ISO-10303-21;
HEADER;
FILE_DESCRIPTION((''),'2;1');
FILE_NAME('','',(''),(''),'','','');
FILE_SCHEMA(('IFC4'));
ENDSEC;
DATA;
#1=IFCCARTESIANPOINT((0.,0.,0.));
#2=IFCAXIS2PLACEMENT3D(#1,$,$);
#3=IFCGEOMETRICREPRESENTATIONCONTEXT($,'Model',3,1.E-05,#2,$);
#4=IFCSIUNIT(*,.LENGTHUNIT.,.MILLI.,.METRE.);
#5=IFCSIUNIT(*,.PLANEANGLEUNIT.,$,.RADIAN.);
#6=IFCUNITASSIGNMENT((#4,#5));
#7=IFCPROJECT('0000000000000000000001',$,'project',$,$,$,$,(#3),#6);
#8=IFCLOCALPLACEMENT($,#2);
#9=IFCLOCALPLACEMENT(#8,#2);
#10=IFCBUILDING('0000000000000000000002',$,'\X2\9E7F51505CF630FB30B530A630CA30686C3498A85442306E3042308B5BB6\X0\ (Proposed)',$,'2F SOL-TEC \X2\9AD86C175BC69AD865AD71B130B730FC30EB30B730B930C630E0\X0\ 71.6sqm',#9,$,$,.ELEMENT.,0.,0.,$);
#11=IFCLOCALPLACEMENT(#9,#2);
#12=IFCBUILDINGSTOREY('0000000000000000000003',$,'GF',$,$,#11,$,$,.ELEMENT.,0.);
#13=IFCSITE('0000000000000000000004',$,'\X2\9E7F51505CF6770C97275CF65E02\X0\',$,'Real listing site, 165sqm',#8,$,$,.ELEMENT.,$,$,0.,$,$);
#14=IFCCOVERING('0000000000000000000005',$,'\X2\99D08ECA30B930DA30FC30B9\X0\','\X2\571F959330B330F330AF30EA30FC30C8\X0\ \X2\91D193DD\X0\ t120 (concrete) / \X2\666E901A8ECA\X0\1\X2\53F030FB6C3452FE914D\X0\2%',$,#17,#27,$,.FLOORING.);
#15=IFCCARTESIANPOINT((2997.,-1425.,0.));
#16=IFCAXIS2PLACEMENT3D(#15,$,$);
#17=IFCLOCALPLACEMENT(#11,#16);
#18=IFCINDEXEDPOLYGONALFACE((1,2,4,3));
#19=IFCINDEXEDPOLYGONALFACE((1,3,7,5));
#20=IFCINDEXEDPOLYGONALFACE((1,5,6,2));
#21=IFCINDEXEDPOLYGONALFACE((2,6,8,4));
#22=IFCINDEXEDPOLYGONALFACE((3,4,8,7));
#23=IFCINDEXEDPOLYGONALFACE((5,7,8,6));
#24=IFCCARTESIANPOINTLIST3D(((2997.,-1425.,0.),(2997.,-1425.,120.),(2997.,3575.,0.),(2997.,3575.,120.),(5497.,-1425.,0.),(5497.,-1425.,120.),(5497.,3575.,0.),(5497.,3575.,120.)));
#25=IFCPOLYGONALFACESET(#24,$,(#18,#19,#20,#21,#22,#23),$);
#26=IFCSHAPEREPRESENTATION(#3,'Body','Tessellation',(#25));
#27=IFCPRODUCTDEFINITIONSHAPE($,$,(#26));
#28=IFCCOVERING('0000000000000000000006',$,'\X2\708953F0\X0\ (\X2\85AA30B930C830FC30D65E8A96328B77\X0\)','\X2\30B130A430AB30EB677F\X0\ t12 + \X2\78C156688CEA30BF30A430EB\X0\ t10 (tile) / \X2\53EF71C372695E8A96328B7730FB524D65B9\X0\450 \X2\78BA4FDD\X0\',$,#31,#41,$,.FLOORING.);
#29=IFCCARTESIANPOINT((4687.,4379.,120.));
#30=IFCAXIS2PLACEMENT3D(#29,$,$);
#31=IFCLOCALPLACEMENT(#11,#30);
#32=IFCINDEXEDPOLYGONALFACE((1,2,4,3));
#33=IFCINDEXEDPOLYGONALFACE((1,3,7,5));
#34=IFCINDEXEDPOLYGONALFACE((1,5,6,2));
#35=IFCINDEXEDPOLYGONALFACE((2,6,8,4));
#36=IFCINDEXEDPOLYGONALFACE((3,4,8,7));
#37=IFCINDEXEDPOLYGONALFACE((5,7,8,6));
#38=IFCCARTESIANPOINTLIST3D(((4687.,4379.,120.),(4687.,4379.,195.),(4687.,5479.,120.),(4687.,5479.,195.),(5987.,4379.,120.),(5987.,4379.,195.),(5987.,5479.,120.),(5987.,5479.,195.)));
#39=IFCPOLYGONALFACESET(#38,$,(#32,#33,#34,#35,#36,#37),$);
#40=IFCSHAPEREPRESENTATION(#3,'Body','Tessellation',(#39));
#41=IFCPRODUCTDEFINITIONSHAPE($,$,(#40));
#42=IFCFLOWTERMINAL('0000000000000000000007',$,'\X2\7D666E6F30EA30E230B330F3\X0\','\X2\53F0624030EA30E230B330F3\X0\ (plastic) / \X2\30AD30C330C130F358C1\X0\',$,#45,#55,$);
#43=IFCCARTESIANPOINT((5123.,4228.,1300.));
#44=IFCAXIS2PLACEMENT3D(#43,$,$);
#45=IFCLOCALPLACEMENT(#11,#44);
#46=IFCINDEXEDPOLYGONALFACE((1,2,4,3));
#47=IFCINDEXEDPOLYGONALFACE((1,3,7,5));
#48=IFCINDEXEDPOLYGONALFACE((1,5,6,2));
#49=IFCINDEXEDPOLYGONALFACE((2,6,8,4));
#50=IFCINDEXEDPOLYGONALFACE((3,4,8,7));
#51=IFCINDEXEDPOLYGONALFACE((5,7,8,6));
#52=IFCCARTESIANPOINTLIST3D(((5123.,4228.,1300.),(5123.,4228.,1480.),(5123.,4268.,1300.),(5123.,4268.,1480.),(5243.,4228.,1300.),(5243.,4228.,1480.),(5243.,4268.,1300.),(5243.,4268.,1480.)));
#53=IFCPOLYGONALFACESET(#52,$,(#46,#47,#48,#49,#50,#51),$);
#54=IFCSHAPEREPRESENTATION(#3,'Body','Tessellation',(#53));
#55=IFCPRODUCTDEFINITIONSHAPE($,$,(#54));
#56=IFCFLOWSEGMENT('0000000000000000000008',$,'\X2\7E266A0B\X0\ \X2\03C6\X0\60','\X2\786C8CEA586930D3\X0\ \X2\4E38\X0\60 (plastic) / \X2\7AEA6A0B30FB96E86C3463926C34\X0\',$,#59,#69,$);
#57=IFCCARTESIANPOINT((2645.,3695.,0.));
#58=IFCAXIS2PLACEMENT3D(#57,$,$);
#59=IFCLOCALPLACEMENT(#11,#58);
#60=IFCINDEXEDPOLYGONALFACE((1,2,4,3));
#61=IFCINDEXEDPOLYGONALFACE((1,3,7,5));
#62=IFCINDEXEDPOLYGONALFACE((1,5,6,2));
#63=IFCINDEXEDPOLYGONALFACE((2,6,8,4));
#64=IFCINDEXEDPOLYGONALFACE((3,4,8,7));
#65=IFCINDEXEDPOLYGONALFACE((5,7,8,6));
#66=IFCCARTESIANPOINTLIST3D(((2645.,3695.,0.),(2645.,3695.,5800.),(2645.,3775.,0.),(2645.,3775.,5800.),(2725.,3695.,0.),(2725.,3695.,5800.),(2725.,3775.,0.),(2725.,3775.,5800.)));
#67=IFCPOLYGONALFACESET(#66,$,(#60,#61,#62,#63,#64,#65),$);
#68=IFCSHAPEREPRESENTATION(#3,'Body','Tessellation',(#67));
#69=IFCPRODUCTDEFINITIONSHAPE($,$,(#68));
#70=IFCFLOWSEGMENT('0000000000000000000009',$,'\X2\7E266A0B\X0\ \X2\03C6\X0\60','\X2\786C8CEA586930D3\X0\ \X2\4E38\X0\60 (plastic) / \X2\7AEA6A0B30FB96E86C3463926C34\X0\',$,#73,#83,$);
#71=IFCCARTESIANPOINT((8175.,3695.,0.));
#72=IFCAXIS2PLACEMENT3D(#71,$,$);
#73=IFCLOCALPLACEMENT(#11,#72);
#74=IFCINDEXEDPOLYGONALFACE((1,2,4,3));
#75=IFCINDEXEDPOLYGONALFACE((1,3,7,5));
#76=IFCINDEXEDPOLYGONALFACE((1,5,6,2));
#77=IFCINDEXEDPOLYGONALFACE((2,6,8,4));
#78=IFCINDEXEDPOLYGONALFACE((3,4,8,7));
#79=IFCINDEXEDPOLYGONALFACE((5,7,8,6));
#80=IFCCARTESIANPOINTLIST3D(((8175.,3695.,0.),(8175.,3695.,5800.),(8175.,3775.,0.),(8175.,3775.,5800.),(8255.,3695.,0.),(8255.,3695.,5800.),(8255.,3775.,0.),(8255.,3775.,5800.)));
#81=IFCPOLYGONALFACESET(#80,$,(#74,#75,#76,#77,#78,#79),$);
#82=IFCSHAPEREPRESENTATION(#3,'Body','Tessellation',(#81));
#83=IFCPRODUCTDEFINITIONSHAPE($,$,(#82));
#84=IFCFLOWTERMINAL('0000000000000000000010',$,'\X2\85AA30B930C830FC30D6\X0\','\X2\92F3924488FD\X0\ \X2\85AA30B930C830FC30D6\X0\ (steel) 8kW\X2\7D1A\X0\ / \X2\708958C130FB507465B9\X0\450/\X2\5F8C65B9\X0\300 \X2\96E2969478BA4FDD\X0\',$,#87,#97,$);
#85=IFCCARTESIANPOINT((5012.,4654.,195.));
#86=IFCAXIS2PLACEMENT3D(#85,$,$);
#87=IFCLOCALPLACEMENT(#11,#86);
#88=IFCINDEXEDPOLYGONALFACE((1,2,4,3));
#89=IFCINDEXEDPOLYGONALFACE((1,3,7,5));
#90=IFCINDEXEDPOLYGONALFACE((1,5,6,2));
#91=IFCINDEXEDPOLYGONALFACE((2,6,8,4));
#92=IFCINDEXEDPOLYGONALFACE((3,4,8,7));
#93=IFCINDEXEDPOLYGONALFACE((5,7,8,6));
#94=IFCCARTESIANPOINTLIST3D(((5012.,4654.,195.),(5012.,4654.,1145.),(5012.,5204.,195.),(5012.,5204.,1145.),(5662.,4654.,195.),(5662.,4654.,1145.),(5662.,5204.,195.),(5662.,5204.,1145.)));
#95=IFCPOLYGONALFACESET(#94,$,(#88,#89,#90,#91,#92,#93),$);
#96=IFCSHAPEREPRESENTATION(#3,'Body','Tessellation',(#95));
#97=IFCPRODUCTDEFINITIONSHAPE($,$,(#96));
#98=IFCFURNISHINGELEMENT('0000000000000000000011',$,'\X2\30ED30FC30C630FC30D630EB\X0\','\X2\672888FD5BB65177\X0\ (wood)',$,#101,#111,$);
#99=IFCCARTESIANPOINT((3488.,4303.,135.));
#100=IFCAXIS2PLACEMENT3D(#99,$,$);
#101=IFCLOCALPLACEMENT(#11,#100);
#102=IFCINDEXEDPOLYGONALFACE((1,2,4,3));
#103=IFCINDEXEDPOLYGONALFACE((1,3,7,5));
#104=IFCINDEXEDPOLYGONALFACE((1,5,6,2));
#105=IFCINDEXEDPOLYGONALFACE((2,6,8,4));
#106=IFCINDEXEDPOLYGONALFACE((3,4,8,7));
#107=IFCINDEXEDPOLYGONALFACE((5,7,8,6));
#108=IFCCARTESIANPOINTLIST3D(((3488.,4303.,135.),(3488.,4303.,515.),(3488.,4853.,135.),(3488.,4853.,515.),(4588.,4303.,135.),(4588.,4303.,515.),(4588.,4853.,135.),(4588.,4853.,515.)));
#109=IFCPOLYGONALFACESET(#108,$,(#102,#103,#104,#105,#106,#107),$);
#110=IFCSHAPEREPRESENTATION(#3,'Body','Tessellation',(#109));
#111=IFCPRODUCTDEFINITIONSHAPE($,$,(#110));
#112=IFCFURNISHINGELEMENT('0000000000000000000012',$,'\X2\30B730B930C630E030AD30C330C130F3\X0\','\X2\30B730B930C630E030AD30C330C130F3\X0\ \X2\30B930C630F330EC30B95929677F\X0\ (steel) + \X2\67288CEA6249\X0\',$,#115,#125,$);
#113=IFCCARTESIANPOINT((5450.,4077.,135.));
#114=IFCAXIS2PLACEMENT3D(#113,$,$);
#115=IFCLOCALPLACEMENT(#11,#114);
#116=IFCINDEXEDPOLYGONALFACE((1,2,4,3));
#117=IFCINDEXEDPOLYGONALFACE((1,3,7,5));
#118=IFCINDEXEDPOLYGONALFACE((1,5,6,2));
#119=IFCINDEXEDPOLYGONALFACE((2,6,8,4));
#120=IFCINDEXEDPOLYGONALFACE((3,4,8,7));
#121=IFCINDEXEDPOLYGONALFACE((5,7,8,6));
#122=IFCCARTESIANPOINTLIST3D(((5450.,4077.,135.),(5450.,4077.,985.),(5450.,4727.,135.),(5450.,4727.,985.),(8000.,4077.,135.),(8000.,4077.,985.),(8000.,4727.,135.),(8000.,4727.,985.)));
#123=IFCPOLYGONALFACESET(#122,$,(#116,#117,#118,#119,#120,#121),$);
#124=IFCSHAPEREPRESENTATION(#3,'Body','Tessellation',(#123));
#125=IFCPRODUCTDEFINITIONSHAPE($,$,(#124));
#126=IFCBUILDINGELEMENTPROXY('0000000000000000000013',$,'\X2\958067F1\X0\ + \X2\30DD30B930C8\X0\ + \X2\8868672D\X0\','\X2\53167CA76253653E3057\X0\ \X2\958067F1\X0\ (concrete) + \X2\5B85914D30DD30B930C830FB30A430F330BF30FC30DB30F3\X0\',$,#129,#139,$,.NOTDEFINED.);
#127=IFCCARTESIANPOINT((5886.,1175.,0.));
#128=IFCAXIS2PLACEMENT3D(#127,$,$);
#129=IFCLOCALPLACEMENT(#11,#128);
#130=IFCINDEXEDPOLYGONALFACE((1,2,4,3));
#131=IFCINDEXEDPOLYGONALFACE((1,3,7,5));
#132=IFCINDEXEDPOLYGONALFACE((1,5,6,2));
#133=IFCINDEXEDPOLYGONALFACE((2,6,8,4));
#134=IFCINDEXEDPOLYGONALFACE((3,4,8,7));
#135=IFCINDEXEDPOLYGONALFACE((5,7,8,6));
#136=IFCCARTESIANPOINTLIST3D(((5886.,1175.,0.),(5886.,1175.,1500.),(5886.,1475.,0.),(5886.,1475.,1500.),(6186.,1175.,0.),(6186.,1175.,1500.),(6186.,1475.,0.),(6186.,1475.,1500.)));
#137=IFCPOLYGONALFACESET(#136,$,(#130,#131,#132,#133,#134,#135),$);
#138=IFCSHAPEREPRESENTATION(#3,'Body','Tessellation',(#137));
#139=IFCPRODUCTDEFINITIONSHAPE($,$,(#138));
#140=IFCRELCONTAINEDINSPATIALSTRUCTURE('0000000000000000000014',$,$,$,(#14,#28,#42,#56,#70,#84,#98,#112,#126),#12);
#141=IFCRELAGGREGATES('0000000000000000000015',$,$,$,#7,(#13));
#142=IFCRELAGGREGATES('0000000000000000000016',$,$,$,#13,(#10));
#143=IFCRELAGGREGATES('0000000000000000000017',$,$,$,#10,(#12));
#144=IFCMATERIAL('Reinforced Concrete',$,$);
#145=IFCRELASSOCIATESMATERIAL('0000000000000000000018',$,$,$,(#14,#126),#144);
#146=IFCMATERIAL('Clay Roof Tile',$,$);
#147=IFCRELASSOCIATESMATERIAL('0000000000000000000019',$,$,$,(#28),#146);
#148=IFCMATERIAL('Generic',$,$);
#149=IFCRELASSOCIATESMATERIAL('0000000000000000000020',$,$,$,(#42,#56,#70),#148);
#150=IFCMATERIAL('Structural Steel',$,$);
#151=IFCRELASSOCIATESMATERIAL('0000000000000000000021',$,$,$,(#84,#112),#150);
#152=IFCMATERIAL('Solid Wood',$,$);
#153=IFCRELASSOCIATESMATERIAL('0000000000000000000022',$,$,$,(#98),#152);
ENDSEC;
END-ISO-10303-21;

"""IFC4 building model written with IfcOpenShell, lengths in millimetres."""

from ifc_helpers import new_model, si_unit, frame, frame_2d, origin, place, context, project, spatial, rectangle, extrude, material, element, save


model = new_model("IFC4")

# Units and contexts
model_context = context("Model", 3, precision=1e-05, world=origin())
ifc_project = project(units=[si_unit("LENGTHUNIT", "METRE", prefix="MILLI"), si_unit("PLANEANGLEUNIT", "RADIAN")], contexts=[model_context])

# Site, building, storey
site_placement = place(None, origin())
site = spatial("IfcSite", under=ifc_project, at=site_placement, Name="鹿児島県霧島市", ObjectType="Real listing site, 165sqm", CompositionType="ELEMENT", RefElevation=0.0)
building_placement = place(site_placement, origin())
building = spatial("IfcBuilding", under=site, at=building_placement, Name="鹿児島・サウナと水風呂のある家 (Proposed)", ObjectType="2F SOL-TEC 高気密高断熱シールシステム 71.6sqm", CompositionType="ELEMENT", ElevationOfRefHeight=0.0, ElevationOfTerrain=0.0)
storey_placement = place(building_placement, origin())
storey = spatial("IfcBuildingStorey", under=building, at=storey_placement, Name="GF", CompositionType="ELEMENT", Elevation=0.0)

# Shared definitions
ifc_material_1 = material(Name="Solid Wood")

# Shared definitions
ifc_material_2 = material(Name="Reinforced Concrete")

# Coverings
ifc_material_3 = material(Name="Generic")
covering_1_placement = place(storey_placement, frame((2997.0, -1425.0, 0.0)))
element("IfcCovering", 1, at=covering_1_placement, inside=storey, material=ifc_material_2, Name="駐車スペース", Description="土間コンクリート 金鏝 t120 (concrete) / 普通車1台・水勾配2%", PredefinedType="FLOORING", context=model_context, shape_type="SweptSolid", body=[
    extrude(rectangle(XDim=2500.0, YDim=5000.0, at=frame_2d((1250.0, 2500.0))), frame((2997.0, -1425.0, 0.0)), (0.0, 0.0, 1.0), 120.0),
])
ifc_material_4 = material(Name="Clay Roof Tile")
covering_2_placement = place(storey_placement, frame((4687.0, 4379.0, 120.0)))
element("IfcCovering", 2, at=covering_2_placement, inside=storey, material=ifc_material_4, Name="炉台 (薪ストーブ床防護)", Description="ケイカル板 t12 + 磁器質タイル t10 (tile) / 可燃物床防護・前方450 確保", PredefinedType="FLOORING", context=model_context, shape_type="SweptSolid", body=[
    extrude(rectangle(XDim=1300.0, YDim=1100.0, at=frame_2d((650.0, 550.0))), frame((4687.0, 4379.0, 120.0)), (0.0, 0.0, 1.0), 75.0),
])

# Flow terminal
flow_terminal_1_placement = place(storey_placement, frame((5123.0, 4228.0, 1300.0)))
element("IfcFlowTerminal", 3, at=flow_terminal_1_placement, inside=storey, material=ifc_material_3, Name="給湯リモコン", Description="台所リモコン (plastic) / キッチン壁", context=model_context, shape_type="SweptSolid", body=[
    extrude(rectangle(XDim=120.0, YDim=40.0, at=frame_2d((60.0, 20.0))), frame((5123.0, 4228.0, 1300.0)), (0.0, 0.0, 1.0), 180.0),
])

# Flow segments
flow_segment_1_placement = place(storey_placement, frame((2645.0, 3695.0, 0.0)))
element("IfcFlowSegment", 4, at=flow_segment_1_placement, inside=storey, material=ifc_material_3, Name="縦樋 φ60", Description="硬質塩ビ 丸60 (plastic) / 竪樋・雨水排水", context=model_context, shape_type="SweptSolid", body=[
    extrude(rectangle(XDim=80.0, YDim=80.0, at=frame_2d((40.0, 40.0))), frame((2645.0, 3695.0, 0.0)), (0.0, 0.0, 1.0), 5800.0),
])
flow_segment_2_placement = place(storey_placement, frame((8175.0, 3695.0, 0.0)))
element("IfcFlowSegment", 5, at=flow_segment_2_placement, inside=storey, material=ifc_material_3, Name="縦樋 φ60", Description="硬質塩ビ 丸60 (plastic) / 竪樋・雨水排水", context=model_context, shape_type="SweptSolid", body=[
    extrude(rectangle(XDim=80.0, YDim=80.0, at=frame_2d((40.0, 40.0))), frame((8175.0, 3695.0, 0.0)), (0.0, 0.0, 1.0), 5800.0),
])

# Flow terminal
ifc_material_5 = material(Name="Structural Steel")
flow_terminal_2_placement = place(storey_placement, frame((5012.0, 4654.0, 195.0)))
element("IfcFlowTerminal", 6, at=flow_terminal_2_placement, inside=storey, material=ifc_material_5, Name="薪ストーブ", Description="鋳鉄製 薪ストーブ (steel) 8kW級 / 炉壁・側方450/後方300 離隔確保", context=model_context, shape_type="SweptSolid", body=[
    extrude(rectangle(XDim=650.0, YDim=550.0, at=frame_2d((325.0, 275.0))), frame((5012.0, 4654.0, 195.0)), (0.0, 0.0, 1.0), 950.0),
])

# Furnishing elements
furnishing_1_placement = place(storey_placement, frame((3488.0, 4303.0, 135.0)))
element("IfcFurnishingElement", 7, at=furnishing_1_placement, inside=storey, material=ifc_material_1, Name="ローテーブル", Description="木製家具 (wood)", context=model_context, shape_type="SweptSolid", body=[
    extrude(rectangle(XDim=1100.0, YDim=550.0, at=frame_2d((550.0, 275.0))), frame((3488.0, 4303.0, 135.0)), (0.0, 0.0, 1.0), 380.0),
])
furnishing_2_placement = place(storey_placement, frame((5450.0, 4077.0, 135.0)))
element("IfcFurnishingElement", 8, at=furnishing_2_placement, inside=storey, material=ifc_material_5, Name="システムキッチン", Description="システムキッチン ステンレス天板 (steel) + 木質扉", context=model_context, shape_type="SweptSolid", body=[
    extrude(rectangle(XDim=2550.0, YDim=650.0, at=frame_2d((1275.0, 325.0))), frame((5450.0, 4077.0, 135.0)), (0.0, 0.0, 1.0), 850.0),
])

# Building element proxy
proxy_placement = place(storey_placement, frame((5886.0, 1175.0, 0.0)))
element("IfcBuildingElementProxy", 9, at=proxy_placement, inside=storey, material=ifc_material_2, Name="門柱 + ポスト + 表札", Description="化粧打放し 門柱 (concrete) + 宅配ポスト・インターホン", PredefinedType="NOTDEFINED", context=model_context, shape_type="SweptSolid", body=[
    extrude(rectangle(XDim=300.0, YDim=300.0, at=frame_2d((150.0, 150.0))), frame((5886.0, 1175.0, 0.0)), (0.0, 0.0, 1.0), 1500.0),
])

save(model, "model.ifc")
